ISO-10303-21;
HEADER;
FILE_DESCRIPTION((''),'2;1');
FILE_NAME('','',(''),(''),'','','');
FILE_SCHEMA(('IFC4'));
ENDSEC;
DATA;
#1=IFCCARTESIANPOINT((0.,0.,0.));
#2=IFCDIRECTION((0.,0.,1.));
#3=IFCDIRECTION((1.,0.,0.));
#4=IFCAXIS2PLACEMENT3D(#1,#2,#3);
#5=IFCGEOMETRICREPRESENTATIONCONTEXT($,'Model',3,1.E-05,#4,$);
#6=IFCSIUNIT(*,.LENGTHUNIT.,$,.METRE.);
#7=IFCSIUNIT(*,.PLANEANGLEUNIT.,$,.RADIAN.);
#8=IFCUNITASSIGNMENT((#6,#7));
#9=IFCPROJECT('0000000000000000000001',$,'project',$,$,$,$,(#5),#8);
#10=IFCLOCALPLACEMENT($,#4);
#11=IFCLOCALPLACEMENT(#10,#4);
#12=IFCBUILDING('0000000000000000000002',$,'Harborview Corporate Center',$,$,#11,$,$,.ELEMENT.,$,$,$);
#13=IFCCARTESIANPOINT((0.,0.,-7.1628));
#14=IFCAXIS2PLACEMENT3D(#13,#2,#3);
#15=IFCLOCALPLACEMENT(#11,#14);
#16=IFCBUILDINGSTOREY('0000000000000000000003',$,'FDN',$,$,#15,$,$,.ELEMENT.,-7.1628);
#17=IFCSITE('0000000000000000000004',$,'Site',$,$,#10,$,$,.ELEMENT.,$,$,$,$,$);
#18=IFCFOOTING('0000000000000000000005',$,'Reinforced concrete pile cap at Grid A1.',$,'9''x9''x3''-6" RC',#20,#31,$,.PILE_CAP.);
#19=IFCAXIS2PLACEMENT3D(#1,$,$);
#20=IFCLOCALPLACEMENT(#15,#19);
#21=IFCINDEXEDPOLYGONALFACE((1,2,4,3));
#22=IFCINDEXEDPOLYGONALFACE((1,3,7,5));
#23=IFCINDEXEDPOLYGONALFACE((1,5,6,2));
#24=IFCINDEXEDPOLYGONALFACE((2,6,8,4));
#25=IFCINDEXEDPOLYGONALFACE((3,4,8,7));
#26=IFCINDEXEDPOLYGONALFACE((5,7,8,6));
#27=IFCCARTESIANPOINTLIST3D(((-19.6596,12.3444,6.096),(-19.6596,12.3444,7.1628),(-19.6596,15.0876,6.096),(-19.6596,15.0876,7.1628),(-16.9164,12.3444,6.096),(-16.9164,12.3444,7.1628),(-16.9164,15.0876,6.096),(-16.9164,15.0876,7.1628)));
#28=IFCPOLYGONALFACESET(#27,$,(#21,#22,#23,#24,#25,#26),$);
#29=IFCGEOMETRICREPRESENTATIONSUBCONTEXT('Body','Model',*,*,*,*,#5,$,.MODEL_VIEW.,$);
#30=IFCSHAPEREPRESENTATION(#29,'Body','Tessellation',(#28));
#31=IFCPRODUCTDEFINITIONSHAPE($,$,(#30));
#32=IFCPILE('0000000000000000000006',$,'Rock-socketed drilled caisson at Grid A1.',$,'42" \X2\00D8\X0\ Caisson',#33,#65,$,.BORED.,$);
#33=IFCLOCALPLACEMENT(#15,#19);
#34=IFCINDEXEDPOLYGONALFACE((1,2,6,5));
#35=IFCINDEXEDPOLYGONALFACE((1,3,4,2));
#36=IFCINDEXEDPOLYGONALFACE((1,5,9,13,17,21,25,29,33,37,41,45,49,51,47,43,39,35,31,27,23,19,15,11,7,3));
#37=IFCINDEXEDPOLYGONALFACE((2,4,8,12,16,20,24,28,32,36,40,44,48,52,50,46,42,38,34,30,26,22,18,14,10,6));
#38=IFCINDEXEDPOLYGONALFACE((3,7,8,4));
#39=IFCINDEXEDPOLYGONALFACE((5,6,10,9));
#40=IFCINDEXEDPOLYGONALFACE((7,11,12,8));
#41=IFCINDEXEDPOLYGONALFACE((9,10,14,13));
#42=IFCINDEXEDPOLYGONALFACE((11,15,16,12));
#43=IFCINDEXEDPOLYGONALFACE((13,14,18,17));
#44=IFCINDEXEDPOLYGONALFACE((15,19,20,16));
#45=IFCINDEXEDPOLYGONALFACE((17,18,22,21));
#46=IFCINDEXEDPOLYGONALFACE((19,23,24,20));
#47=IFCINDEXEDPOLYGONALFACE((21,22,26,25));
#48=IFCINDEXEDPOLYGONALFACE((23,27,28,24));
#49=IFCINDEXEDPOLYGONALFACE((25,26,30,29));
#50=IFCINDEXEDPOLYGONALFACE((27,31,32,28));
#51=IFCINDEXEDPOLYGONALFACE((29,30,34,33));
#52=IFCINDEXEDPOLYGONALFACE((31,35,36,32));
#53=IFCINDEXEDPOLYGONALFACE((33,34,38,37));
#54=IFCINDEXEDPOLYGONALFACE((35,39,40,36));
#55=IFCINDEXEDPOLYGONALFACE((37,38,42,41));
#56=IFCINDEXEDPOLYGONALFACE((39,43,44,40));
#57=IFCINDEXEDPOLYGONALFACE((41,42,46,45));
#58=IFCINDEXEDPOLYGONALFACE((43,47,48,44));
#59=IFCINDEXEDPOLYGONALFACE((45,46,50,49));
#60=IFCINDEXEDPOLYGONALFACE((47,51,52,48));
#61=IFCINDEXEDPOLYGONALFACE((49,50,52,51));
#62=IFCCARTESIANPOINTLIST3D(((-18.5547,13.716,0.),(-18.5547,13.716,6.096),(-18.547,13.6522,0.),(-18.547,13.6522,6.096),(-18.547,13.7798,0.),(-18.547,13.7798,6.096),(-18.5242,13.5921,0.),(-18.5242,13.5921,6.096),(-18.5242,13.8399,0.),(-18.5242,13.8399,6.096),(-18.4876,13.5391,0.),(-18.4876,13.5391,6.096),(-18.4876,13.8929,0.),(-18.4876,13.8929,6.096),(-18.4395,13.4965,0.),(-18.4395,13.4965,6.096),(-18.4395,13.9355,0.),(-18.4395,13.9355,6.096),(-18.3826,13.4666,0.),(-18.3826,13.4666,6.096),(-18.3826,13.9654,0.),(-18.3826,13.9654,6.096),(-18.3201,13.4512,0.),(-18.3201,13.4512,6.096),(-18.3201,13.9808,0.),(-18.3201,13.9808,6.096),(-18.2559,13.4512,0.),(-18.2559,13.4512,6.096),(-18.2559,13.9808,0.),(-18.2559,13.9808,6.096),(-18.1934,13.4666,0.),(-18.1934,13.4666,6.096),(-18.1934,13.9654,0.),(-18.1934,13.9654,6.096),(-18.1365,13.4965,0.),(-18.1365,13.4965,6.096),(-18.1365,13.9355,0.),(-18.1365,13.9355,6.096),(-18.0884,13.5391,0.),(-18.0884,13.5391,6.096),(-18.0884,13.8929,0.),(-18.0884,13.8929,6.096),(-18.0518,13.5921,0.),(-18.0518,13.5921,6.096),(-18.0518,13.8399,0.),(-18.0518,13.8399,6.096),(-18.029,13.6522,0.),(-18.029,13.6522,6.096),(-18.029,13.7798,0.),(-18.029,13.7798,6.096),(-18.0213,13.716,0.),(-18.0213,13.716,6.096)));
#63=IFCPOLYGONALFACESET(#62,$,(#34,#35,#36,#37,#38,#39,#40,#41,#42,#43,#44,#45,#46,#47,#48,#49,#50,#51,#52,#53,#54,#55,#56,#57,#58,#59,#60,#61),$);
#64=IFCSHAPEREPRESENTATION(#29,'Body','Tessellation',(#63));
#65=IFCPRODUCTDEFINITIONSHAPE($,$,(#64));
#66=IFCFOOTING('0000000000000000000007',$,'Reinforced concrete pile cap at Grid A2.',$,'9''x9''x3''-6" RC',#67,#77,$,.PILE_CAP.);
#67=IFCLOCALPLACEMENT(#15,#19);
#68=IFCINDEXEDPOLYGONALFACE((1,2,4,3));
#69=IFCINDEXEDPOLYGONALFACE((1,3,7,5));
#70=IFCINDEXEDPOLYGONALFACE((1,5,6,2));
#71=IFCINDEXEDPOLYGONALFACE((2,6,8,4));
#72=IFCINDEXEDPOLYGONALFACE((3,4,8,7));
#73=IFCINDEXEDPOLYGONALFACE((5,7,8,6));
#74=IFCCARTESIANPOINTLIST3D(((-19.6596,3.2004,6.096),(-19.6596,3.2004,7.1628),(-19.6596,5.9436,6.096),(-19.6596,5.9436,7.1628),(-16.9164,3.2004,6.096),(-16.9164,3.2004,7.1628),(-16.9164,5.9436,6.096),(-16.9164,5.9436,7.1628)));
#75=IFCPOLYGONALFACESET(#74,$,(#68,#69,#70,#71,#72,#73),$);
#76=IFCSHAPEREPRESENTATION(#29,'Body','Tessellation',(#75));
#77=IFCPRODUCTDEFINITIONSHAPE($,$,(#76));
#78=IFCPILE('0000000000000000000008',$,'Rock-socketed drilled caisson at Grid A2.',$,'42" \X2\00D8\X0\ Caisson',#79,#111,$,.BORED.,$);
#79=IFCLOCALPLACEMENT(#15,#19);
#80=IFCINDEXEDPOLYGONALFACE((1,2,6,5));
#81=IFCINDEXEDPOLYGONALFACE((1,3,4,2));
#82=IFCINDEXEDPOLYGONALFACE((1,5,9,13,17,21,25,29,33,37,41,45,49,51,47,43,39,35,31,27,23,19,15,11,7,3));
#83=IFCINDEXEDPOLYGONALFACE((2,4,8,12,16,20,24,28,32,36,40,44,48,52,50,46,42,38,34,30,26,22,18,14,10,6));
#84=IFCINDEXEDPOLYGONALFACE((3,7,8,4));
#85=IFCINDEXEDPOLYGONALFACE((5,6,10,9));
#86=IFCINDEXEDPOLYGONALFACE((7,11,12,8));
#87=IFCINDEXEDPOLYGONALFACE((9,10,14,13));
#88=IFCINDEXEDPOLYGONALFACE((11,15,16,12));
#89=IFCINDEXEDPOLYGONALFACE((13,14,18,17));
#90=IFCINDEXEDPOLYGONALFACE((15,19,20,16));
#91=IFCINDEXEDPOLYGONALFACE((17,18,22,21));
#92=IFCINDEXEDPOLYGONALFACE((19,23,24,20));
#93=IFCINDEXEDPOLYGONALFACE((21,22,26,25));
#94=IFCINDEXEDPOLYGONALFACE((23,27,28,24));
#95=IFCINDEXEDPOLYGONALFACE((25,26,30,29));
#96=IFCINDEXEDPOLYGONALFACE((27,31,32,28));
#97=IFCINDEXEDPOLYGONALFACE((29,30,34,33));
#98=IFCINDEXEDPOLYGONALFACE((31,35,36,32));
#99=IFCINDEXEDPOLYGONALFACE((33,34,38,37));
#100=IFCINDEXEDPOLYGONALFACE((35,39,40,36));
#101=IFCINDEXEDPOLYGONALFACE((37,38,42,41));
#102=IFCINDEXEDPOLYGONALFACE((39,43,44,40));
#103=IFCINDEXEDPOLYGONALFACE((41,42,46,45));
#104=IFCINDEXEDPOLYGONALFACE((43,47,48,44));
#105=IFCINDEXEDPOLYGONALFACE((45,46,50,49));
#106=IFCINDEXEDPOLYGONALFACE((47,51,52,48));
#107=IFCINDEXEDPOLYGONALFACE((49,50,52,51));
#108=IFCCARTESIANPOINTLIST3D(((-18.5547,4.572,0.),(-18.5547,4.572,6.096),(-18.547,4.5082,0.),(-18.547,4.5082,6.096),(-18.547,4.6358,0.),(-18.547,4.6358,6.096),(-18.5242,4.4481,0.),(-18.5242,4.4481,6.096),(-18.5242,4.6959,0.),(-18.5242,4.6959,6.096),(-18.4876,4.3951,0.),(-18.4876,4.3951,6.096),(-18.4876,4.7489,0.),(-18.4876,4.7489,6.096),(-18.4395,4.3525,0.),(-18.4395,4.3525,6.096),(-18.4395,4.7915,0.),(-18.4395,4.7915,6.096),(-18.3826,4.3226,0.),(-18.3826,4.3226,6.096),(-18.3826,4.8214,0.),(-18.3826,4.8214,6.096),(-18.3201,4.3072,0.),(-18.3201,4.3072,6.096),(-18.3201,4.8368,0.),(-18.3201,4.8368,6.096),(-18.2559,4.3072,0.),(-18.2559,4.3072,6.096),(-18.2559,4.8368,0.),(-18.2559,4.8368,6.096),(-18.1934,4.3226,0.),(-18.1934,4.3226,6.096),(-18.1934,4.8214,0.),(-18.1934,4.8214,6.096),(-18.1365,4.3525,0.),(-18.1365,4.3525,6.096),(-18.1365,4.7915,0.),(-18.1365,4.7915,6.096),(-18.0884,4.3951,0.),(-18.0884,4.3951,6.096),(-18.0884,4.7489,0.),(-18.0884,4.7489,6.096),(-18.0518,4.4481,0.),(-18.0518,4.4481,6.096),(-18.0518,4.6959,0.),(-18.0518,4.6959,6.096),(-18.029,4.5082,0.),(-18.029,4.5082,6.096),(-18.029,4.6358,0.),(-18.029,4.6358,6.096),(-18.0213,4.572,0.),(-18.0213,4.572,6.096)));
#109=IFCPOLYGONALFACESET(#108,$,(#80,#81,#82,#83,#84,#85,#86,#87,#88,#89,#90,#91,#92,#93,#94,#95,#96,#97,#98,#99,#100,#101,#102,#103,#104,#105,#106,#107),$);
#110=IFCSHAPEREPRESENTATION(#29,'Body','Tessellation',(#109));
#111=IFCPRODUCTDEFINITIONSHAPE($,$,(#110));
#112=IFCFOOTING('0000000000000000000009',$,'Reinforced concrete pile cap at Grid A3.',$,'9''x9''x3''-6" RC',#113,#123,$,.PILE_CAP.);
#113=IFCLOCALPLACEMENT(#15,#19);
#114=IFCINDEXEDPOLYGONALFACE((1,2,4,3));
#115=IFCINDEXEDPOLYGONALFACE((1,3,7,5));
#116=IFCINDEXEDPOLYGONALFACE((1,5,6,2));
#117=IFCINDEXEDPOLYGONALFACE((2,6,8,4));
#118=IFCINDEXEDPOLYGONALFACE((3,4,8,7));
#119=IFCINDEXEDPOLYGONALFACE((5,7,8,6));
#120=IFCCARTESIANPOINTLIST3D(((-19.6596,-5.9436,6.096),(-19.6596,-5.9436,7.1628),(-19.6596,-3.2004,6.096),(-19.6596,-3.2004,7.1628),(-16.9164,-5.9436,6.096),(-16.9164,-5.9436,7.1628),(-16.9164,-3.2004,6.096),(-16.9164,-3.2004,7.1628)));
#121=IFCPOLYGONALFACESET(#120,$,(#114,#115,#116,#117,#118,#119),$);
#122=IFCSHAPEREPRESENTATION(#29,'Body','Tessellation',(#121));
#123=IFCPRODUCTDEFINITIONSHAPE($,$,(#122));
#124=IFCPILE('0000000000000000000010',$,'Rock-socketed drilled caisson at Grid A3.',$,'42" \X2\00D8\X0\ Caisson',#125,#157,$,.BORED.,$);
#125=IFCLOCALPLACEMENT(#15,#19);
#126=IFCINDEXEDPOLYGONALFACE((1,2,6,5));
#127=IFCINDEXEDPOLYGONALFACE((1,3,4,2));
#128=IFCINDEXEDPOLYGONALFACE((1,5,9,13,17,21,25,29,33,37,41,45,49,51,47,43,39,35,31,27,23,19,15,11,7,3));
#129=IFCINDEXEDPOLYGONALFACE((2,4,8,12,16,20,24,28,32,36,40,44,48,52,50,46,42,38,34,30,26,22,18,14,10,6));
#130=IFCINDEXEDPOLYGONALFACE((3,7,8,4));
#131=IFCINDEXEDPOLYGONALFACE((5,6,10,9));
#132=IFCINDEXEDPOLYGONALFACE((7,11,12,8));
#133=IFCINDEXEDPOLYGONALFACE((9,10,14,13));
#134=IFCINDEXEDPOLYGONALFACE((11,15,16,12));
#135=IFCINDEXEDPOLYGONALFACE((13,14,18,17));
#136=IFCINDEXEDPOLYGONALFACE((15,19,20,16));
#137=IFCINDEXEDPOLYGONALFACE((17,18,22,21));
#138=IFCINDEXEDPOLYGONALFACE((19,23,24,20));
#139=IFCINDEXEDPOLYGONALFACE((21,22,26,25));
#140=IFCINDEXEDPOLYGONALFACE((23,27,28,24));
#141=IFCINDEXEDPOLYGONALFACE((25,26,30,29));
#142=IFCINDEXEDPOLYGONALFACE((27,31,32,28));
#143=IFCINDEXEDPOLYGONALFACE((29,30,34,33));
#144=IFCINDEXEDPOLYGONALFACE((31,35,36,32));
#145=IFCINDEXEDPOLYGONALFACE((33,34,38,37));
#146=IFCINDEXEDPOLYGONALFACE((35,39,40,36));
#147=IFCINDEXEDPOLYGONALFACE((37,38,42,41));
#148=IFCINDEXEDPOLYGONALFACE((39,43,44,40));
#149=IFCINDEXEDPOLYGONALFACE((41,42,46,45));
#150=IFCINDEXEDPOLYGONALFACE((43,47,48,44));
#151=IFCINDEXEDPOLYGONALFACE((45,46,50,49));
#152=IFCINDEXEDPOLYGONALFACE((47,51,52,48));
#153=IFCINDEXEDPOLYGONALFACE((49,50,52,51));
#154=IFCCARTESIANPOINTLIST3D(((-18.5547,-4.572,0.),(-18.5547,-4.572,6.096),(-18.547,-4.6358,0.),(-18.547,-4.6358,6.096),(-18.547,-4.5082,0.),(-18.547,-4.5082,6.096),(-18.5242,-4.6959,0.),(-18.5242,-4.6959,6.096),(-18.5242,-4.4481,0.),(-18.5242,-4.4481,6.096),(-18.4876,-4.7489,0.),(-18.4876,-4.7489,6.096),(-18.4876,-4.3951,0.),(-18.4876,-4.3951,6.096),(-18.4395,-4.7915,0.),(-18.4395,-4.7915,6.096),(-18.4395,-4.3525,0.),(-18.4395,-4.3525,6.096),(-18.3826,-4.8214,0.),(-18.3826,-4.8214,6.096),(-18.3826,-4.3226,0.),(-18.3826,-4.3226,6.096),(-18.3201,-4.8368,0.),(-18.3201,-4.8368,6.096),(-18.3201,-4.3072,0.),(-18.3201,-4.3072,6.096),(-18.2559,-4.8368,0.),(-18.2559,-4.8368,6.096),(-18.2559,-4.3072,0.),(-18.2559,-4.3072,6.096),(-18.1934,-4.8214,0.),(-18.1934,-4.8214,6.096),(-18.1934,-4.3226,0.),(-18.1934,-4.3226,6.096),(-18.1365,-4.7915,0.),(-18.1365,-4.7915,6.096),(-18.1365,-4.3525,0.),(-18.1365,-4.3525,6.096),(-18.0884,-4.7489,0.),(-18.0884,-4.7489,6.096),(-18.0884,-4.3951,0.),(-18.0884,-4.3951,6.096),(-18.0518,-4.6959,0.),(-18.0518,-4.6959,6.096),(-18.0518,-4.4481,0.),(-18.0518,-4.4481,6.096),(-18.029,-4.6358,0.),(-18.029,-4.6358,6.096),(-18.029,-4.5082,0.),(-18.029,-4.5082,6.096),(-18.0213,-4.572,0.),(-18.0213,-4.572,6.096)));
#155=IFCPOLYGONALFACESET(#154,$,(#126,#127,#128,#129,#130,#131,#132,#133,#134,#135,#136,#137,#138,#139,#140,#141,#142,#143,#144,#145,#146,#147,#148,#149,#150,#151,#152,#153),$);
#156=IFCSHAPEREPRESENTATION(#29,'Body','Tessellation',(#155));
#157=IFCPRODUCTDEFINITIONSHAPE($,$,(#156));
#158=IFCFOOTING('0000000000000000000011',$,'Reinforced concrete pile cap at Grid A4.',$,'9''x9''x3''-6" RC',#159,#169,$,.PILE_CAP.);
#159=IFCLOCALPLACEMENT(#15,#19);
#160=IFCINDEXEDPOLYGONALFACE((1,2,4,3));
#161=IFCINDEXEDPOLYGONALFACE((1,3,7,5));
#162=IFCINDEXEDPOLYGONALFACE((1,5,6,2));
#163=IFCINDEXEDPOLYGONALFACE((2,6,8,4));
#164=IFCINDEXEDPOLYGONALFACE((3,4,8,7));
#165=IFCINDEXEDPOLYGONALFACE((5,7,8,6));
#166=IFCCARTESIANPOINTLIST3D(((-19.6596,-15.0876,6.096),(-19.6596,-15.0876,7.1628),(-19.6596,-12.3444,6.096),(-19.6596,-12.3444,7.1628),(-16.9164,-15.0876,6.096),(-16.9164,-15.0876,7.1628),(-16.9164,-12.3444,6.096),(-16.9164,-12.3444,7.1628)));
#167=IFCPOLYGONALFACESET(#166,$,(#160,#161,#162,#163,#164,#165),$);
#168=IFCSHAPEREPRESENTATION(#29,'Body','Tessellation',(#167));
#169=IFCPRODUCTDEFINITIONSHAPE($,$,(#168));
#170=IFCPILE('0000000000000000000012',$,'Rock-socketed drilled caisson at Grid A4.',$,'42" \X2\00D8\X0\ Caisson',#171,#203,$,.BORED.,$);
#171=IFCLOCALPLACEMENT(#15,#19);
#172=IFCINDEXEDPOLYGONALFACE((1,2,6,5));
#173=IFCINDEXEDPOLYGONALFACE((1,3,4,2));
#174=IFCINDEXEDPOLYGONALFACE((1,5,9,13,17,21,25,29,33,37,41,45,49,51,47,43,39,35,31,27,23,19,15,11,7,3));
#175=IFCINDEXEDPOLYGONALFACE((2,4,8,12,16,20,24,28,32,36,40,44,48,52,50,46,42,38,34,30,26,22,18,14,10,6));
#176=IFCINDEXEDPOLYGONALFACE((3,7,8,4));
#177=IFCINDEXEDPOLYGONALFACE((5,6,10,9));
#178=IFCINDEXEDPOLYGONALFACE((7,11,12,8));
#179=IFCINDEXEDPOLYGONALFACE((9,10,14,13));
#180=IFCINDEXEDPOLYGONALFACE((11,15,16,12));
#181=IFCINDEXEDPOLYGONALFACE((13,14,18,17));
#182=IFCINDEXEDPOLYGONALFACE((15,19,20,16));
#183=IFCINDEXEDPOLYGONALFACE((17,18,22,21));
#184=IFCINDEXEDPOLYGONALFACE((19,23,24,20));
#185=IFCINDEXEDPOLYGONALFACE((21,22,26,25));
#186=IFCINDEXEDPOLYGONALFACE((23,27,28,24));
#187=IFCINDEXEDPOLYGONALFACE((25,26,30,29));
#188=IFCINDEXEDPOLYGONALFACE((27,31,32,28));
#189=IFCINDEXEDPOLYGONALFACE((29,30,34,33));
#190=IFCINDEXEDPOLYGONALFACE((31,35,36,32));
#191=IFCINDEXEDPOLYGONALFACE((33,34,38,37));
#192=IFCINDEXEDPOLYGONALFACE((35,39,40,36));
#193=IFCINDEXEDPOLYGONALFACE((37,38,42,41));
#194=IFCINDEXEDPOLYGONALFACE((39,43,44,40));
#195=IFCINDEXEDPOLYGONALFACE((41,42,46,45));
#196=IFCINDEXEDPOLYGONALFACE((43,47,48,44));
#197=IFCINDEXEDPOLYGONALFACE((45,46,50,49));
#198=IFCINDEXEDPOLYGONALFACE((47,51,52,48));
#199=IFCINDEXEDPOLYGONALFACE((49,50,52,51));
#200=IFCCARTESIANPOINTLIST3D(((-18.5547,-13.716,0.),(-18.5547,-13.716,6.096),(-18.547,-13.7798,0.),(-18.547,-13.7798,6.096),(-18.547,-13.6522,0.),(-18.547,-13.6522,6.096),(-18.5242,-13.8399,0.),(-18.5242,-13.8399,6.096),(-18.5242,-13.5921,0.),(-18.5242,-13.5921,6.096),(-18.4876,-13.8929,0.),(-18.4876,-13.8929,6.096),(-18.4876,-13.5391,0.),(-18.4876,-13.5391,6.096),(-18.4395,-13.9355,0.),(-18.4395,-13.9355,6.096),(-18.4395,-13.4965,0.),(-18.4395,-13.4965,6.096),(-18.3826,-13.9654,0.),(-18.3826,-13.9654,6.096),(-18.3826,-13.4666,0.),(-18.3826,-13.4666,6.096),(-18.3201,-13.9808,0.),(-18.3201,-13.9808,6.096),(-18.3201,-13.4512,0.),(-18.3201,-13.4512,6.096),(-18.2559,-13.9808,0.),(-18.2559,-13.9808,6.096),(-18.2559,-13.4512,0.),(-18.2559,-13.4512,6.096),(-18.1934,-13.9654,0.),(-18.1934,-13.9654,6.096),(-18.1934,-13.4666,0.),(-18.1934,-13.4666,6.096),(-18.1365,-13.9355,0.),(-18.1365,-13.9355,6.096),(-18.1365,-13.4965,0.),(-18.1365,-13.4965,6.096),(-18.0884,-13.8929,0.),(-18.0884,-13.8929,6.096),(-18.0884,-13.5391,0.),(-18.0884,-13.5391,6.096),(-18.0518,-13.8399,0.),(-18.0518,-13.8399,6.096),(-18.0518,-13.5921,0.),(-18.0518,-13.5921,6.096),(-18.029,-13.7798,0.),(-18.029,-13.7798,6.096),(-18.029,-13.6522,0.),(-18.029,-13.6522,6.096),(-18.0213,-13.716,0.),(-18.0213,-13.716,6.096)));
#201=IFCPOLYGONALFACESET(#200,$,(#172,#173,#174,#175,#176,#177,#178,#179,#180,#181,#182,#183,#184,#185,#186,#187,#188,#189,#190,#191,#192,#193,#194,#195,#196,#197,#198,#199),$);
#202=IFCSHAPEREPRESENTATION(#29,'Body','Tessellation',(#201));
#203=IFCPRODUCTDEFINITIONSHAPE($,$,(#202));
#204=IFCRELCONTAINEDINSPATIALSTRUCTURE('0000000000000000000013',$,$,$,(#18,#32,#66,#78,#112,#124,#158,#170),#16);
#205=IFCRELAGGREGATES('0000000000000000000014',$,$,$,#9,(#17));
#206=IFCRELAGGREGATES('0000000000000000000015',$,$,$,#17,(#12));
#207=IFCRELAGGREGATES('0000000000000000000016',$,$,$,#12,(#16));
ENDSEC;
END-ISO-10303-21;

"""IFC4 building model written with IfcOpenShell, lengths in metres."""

from ifc_helpers import new_model, si_unit, frame, origin_with_axes, place, context, subcontext, project, spatial, rectangle, circle, extrude, element, save


model = new_model("IFC4")

# Units and contexts
model_context = context("Model", 3, precision=1e-05, world=origin_with_axes())
body_context = subcontext(model_context, "Body", "Model", "MODEL_VIEW")
ifc_project = project(units=[si_unit("LENGTHUNIT", "METRE"), si_unit("PLANEANGLEUNIT", "RADIAN")], contexts=[model_context])

# Site, building, storey
site_placement = place(None, origin_with_axes())
site = spatial("IfcSite", under=ifc_project, at=site_placement, Name="Site", CompositionType="ELEMENT")
building_placement = place(site_placement, origin_with_axes())
building = spatial("IfcBuilding", under=site, at=building_placement, Name="Harborview Corporate Center", CompositionType="ELEMENT")
storey_placement = place(building_placement, frame((0.0, 0.0, -7.1628), z_axis=(0.0, 0.0, 1.0), x_axis=(1.0, 0.0, 0.0)))
storey = spatial("IfcBuildingStorey", under=building, at=storey_placement, Name="FDN", CompositionType="ELEMENT", Elevation=-7.1628)

# Footing
footing_1_placement = place(storey_placement, frame((-18.288, 13.716, 6.096), z_axis=(0.0, 0.0, 1.0), x_axis=(1.0, 0.0, 0.0)))
element("IfcFooting", 1, at=footing_1_placement, inside=storey, Name="Reinforced concrete pile cap at Grid A1.", ObjectType="9'x9'x3'-6\" RC", PredefinedType="PILE_CAP", context=body_context, shape_type="SweptSolid", body=[
    extrude(rectangle(XDim=2.7432, YDim=2.7432), origin_with_axes(), (0.0, 0.0, 1.0), 1.0668),
])

# Pile
pile_1_placement = place(storey_placement, frame((-18.288, 13.716, 0.0), z_axis=(0.0, 0.0, 1.0), x_axis=(1.0, 0.0, 0.0)))
element("IfcPile", 2, at=pile_1_placement, inside=storey, Name="Rock-socketed drilled caisson at Grid A1.", ObjectType="42\" Ø Caisson", PredefinedType="BORED", context=body_context, shape_type="SweptSolid", body=[
    extrude(circle(Radius=0.2667), origin_with_axes(), (0.0, 0.0, 1.0), 6.096),
])

# Footing
footing_2_placement = place(storey_placement, frame((-18.288, 4.572, 6.096), z_axis=(0.0, 0.0, 1.0), x_axis=(1.0, 0.0, 0.0)))
element("IfcFooting", 3, at=footing_2_placement, inside=storey, Name="Reinforced concrete pile cap at Grid A2.", ObjectType="9'x9'x3'-6\" RC", PredefinedType="PILE_CAP", context=body_context, shape_type="SweptSolid", body=[
    extrude(rectangle(XDim=2.7432, YDim=2.7432), origin_with_axes(), (0.0, 0.0, 1.0), 1.0668),
])

# Pile
pile_2_placement = place(storey_placement, frame((-18.288, 4.572, 0.0), z_axis=(0.0, 0.0, 1.0), x_axis=(1.0, 0.0, 0.0)))
element("IfcPile", 4, at=pile_2_placement, inside=storey, Name="Rock-socketed drilled caisson at Grid A2.", ObjectType="42\" Ø Caisson", PredefinedType="BORED", context=body_context, shape_type="SweptSolid", body=[
    extrude(circle(Radius=0.2667), origin_with_axes(), (0.0, 0.0, 1.0), 6.096),
])

# Footing
footing_3_placement = place(storey_placement, frame((-18.288, -4.572, 6.096), z_axis=(0.0, 0.0, 1.0), x_axis=(1.0, 0.0, 0.0)))
element("IfcFooting", 5, at=footing_3_placement, inside=storey, Name="Reinforced concrete pile cap at Grid A3.", ObjectType="9'x9'x3'-6\" RC", PredefinedType="PILE_CAP", context=body_context, shape_type="SweptSolid", body=[
    extrude(rectangle(XDim=2.7432, YDim=2.7432), origin_with_axes(), (0.0, 0.0, 1.0), 1.0668),
])

# Pile
pile_3_placement = place(storey_placement, frame((-18.288, -4.572, 0.0), z_axis=(0.0, 0.0, 1.0), x_axis=(1.0, 0.0, 0.0)))
element("IfcPile", 6, at=pile_3_placement, inside=storey, Name="Rock-socketed drilled caisson at Grid A3.", ObjectType="42\" Ø Caisson", PredefinedType="BORED", context=body_context, shape_type="SweptSolid", body=[
    extrude(circle(Radius=0.2667), origin_with_axes(), (0.0, 0.0, 1.0), 6.096),
])

# Footing
footing_4_placement = place(storey_placement, frame((-18.288, -13.716, 6.096), z_axis=(0.0, 0.0, 1.0), x_axis=(1.0, 0.0, 0.0)))
element("IfcFooting", 7, at=footing_4_placement, inside=storey, Name="Reinforced concrete pile cap at Grid A4.", ObjectType="9'x9'x3'-6\" RC", PredefinedType="PILE_CAP", context=body_context, shape_type="SweptSolid", body=[
    extrude(rectangle(XDim=2.7432, YDim=2.7432), origin_with_axes(), (0.0, 0.0, 1.0), 1.0668),
])

# Pile
pile_4_placement = place(storey_placement, frame((-18.288, -13.716, 0.0), z_axis=(0.0, 0.0, 1.0), x_axis=(1.0, 0.0, 0.0)))
element("IfcPile", 8, at=pile_4_placement, inside=storey, Name="Rock-socketed drilled caisson at Grid A4.", ObjectType="42\" Ø Caisson", PredefinedType="BORED", context=body_context, shape_type="SweptSolid", body=[
    extrude(circle(Radius=0.2667), origin_with_axes(), (0.0, 0.0, 1.0), 6.096),
])

save(model, "model.ifc")
